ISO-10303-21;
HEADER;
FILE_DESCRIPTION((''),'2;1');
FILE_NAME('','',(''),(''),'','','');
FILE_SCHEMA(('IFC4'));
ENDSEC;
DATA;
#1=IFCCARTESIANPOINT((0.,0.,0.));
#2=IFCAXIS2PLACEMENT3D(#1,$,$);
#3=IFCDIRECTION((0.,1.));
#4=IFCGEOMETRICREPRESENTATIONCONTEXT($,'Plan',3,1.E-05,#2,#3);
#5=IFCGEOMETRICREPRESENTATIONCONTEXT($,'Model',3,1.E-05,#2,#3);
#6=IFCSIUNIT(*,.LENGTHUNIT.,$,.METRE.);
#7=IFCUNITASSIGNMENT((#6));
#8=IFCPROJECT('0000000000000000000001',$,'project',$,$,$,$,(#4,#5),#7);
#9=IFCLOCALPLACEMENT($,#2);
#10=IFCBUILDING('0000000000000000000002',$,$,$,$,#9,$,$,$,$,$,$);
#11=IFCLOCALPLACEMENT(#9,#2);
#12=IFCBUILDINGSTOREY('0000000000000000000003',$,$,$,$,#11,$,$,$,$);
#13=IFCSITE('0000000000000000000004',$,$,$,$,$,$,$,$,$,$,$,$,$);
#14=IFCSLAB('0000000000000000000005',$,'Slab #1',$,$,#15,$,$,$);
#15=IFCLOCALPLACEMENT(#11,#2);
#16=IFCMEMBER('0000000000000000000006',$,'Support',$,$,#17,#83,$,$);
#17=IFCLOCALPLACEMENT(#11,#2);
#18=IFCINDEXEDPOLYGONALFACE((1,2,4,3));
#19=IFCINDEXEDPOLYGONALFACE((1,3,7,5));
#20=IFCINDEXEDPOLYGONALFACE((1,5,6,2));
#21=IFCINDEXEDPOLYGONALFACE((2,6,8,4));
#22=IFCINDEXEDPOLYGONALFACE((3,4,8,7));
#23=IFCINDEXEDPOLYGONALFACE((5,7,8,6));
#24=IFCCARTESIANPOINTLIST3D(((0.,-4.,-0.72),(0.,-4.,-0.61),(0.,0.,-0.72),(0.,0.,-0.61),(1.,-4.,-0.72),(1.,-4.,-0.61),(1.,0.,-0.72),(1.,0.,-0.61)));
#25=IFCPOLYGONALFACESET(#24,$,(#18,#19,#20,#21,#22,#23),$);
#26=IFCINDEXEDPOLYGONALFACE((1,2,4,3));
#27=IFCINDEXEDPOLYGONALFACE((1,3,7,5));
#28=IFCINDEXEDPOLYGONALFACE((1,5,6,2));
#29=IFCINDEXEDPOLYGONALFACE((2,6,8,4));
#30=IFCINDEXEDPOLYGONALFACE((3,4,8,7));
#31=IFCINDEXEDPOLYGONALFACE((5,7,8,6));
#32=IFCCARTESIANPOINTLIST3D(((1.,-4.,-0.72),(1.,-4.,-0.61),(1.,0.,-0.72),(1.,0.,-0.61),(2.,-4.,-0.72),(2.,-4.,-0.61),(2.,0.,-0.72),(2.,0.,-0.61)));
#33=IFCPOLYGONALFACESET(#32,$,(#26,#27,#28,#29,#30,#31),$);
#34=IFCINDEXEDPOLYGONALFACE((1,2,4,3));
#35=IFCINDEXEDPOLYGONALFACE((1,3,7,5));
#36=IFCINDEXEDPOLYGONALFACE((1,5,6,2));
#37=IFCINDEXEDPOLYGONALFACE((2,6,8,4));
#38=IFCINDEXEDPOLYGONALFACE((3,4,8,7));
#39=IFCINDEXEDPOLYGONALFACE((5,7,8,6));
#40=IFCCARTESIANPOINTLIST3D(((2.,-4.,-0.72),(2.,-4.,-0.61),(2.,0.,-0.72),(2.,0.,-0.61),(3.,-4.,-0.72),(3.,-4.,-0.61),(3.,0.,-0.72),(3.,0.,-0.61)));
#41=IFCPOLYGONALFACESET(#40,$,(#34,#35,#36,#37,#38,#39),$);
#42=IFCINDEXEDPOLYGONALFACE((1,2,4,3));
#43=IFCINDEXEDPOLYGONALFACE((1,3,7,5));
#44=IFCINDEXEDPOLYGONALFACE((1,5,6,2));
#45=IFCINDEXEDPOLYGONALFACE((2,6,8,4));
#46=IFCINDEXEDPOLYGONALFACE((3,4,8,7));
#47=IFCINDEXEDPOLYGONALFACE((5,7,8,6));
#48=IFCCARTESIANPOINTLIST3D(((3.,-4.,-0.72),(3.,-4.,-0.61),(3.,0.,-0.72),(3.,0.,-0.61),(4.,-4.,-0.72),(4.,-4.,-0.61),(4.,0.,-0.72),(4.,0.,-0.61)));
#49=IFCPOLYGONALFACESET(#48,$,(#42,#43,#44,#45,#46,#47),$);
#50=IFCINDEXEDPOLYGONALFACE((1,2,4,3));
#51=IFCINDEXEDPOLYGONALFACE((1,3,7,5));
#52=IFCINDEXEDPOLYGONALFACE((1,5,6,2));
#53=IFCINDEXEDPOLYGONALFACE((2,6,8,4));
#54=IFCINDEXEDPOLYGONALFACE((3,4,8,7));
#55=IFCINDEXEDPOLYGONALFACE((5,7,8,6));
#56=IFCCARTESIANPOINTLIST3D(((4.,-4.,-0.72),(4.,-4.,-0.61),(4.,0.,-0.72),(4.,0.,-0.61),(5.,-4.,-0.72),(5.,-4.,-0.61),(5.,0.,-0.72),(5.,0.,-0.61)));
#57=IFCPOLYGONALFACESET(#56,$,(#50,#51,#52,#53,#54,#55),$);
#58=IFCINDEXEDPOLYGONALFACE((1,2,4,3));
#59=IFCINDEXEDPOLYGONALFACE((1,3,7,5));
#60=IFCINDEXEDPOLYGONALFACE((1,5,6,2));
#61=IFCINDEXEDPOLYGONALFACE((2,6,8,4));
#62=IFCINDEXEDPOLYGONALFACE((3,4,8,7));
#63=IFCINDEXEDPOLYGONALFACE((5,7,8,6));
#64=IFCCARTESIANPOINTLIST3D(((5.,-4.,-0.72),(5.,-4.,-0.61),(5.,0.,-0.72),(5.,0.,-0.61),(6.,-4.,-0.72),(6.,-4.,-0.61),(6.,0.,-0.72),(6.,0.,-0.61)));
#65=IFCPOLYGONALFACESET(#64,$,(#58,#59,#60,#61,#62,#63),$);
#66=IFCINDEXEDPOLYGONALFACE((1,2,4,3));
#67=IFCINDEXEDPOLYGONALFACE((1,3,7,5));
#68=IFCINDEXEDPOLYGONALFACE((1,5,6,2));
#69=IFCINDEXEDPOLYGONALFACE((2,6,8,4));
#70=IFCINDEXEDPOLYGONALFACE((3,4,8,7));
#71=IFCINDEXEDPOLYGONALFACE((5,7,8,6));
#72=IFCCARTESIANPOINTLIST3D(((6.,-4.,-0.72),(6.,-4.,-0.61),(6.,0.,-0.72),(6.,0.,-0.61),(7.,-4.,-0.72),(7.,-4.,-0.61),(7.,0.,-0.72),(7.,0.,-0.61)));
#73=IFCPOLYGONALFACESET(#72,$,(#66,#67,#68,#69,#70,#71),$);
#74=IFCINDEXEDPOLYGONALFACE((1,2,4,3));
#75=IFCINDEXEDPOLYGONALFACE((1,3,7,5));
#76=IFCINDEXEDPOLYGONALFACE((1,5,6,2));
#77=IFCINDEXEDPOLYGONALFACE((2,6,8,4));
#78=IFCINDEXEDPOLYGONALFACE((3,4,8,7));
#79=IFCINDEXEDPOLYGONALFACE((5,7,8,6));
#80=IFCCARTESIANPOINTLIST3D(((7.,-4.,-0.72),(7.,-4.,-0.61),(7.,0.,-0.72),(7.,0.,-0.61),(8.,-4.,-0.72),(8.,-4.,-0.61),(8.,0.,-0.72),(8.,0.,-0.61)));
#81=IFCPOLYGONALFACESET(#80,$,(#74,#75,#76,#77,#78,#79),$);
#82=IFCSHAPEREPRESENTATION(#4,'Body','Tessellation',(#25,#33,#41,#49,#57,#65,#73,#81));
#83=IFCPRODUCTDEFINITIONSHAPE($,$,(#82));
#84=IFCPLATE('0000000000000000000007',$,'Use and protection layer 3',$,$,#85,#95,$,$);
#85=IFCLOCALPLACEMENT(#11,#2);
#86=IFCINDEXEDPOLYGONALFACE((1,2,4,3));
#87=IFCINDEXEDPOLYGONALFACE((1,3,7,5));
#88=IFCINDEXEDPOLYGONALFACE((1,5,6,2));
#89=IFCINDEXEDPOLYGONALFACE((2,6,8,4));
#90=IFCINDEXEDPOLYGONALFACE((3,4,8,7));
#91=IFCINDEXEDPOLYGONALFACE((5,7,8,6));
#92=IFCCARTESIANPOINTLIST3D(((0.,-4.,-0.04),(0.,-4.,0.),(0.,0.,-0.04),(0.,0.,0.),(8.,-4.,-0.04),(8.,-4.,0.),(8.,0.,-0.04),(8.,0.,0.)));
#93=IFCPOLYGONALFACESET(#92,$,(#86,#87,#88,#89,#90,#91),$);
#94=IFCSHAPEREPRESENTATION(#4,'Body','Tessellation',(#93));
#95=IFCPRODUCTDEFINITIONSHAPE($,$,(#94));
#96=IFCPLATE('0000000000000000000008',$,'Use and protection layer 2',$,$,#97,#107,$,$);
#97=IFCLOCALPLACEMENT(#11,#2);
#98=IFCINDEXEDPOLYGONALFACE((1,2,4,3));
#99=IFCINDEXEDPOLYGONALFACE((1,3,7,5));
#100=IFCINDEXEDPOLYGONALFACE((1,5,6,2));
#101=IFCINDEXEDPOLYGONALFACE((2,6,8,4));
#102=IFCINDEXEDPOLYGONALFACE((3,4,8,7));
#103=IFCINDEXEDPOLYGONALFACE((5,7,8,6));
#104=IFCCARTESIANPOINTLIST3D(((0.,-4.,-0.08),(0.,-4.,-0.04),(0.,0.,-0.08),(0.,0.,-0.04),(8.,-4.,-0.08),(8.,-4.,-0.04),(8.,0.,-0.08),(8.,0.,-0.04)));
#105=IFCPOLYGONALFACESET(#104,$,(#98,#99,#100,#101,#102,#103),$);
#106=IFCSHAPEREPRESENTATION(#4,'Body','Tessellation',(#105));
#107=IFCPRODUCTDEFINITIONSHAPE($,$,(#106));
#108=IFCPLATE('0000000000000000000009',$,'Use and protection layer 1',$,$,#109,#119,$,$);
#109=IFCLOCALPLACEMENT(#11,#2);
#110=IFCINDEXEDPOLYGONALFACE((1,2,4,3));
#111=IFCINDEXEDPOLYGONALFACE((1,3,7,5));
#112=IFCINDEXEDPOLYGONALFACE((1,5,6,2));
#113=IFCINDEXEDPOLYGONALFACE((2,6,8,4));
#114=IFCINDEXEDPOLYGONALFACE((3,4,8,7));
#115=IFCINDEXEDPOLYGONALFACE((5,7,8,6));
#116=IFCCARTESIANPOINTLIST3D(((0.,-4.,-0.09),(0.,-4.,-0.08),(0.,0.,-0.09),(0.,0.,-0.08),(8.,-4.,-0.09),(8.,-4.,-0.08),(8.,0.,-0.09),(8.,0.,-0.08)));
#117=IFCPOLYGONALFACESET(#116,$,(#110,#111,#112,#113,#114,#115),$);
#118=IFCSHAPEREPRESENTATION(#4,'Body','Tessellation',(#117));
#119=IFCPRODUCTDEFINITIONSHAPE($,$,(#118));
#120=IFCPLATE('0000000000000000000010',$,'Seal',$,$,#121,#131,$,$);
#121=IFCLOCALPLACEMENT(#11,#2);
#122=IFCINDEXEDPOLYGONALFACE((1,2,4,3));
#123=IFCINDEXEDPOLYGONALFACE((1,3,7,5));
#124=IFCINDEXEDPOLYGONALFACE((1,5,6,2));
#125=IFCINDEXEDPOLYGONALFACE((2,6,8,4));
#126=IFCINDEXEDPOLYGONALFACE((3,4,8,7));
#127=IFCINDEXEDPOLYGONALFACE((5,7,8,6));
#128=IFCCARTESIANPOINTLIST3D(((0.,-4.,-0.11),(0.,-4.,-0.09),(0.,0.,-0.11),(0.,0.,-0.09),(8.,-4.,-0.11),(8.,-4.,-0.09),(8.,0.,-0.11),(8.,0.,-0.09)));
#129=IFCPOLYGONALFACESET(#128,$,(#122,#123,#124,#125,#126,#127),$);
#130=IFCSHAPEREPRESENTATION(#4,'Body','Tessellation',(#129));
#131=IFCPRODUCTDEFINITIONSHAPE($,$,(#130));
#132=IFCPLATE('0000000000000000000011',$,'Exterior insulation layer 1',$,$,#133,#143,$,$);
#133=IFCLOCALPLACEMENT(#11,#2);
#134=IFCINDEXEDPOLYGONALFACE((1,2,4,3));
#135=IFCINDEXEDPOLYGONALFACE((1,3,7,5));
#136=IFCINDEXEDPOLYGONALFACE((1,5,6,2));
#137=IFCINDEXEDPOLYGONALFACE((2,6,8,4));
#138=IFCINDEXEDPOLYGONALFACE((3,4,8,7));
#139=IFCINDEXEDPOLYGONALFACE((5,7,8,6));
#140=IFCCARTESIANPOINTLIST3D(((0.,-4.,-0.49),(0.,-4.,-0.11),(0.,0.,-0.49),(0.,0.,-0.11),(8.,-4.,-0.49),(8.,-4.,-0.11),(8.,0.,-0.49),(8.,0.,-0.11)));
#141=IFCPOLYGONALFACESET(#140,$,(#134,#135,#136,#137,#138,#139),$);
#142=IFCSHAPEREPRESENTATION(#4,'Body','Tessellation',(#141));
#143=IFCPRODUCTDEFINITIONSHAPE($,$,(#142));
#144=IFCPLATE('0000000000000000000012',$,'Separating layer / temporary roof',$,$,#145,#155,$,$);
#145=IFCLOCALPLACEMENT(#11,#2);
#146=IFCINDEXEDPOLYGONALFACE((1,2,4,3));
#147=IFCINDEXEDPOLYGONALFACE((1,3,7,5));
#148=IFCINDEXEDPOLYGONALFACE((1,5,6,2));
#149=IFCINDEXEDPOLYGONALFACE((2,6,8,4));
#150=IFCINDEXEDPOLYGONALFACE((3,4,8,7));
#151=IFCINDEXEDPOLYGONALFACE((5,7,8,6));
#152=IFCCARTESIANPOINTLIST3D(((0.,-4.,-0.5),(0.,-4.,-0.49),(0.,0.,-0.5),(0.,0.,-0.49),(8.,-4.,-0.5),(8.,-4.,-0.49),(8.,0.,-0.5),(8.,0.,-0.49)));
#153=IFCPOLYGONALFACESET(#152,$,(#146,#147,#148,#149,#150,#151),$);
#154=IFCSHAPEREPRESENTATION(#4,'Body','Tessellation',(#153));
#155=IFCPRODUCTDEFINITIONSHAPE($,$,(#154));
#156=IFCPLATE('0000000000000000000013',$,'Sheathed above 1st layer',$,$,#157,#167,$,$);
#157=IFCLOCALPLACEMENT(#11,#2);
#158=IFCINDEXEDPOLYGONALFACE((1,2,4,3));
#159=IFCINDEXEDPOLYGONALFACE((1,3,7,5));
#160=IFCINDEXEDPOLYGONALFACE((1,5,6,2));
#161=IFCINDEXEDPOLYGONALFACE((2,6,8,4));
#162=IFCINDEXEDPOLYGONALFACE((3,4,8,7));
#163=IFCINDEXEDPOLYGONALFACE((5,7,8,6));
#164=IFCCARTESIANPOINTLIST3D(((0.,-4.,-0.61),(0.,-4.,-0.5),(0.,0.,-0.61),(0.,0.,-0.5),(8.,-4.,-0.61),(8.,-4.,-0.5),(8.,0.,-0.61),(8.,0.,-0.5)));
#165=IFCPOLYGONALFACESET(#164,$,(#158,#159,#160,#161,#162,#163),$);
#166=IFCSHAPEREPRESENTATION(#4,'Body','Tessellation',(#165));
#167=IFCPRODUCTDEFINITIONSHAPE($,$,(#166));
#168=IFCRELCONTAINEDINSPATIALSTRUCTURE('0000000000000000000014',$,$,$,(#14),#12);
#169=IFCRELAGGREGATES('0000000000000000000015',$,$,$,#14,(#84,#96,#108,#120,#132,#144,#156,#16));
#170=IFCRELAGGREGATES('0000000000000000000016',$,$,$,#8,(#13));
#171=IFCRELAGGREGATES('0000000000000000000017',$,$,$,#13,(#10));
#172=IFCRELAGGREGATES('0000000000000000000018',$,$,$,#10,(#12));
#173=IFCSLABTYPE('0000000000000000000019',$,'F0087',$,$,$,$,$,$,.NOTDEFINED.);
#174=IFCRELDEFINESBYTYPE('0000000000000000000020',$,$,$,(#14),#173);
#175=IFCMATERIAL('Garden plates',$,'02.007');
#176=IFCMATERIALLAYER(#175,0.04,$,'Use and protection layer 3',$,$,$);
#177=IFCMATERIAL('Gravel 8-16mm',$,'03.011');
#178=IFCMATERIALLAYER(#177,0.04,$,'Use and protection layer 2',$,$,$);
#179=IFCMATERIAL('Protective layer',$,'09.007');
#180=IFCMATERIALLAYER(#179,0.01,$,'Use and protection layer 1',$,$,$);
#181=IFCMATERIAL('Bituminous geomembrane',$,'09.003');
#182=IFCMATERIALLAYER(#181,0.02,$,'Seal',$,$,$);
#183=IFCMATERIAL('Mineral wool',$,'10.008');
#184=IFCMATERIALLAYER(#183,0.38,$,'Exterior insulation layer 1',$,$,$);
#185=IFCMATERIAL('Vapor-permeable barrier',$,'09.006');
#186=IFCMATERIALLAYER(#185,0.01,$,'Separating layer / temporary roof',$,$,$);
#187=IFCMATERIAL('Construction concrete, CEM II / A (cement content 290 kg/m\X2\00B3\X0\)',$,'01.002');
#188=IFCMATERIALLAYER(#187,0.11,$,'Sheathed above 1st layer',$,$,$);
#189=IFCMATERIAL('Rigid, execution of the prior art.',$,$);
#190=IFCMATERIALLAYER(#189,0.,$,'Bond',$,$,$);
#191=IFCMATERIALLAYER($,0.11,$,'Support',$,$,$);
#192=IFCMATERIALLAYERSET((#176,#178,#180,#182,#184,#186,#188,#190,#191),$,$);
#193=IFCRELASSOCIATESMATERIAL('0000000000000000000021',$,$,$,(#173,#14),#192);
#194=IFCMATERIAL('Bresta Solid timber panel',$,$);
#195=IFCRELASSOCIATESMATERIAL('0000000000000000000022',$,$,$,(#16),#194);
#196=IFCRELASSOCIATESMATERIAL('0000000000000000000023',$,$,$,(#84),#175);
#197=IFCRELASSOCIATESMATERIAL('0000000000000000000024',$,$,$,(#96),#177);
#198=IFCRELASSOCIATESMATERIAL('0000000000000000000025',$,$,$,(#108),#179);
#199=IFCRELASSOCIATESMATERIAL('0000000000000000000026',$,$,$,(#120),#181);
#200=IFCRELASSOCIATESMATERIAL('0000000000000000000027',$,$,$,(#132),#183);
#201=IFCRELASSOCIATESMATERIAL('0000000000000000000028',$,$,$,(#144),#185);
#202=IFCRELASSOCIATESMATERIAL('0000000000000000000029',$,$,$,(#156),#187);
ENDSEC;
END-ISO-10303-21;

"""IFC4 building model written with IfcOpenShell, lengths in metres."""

from ifc_helpers import new_model, si_unit, direction, frame, frame_2d, origin, origin_with_axes, place, context, project, spatial, rectangle, extrude, material, layer, layer_set, type_object, element, aggregate, save


model = new_model("IFC4")

# Units and contexts
plan_context = context("Plan", 3, precision=1e-05, world=origin(), true_north=direction((0.0, 1.0)))
model_context = context("Model", 3, precision=1e-05, world=origin(), true_north=direction((0.0, 1.0)))
ifc_project = project(units=[si_unit("LENGTHUNIT", "METRE")], contexts=[plan_context, model_context])

# Site, building, storey
site = spatial("IfcSite", under=ifc_project)
building_placement = place(None, origin())
building = spatial("IfcBuilding", under=site, at=building_placement)
storey_placement = place(building_placement, origin())
storey = spatial("IfcBuildingStorey", under=building, at=storey_placement)

# Slab, member, plates
ifc_material_1 = material(Name="Garden plates", Category="02.007")
ifc_layer_1 = layer(ifc_material_1, 0.04, Name="Use and protection layer 3")
ifc_material_2 = material(Name="Gravel 8-16mm", Category="03.011")
ifc_layer_2 = layer(ifc_material_2, 0.04, Name="Use and protection layer 2")
ifc_material_3 = material(Name="Protective layer", Category="09.007")
ifc_layer_3 = layer(ifc_material_3, 0.01, Name="Use and protection layer 1")
ifc_material_4 = material(Name="Bituminous geomembrane", Category="09.003")
ifc_layer_4 = layer(ifc_material_4, 0.02, Name="Seal")
ifc_material_5 = material(Name="Mineral wool", Category="10.008")
ifc_layer_5 = layer(ifc_material_5, 0.38, Name="Exterior insulation layer 1")
ifc_material_6 = material(Name="Vapor-permeable barrier", Category="09.006")
ifc_layer_6 = layer(ifc_material_6, 0.01, Name="Separating layer / temporary roof")
ifc_material_7 = material(Name="Construction concrete, CEM II / A (cement content 290 kg/m³)", Category="01.002")
ifc_layer_7 = layer(ifc_material_7, 0.11, Name="Sheathed above 1st layer")
ifc_material_8 = material(Name="Rigid, execution of the prior art.")
ifc_layer_8 = layer(ifc_material_8, 0.0, Name="Bond")
ifc_layer_9 = layer(None, 0.11, Name="Support")
ifc_layer_set = layer_set([ifc_layer_1, ifc_layer_2, ifc_layer_3, ifc_layer_4, ifc_layer_5, ifc_layer_6, ifc_layer_7, ifc_layer_8, ifc_layer_9])
slab_type = type_object("IfcSlabType", Name="F0087", PredefinedType="NOTDEFINED", material=ifc_layer_set)
slab_placement = place(None, frame((0.0, 0.0, 0.0), z_axis=(0.0, 0.0, -1.0), x_axis=(1.0, 0.0, 0.0)))
slab = element("IfcSlab", 1, at=slab_placement, inside=storey, type_object=slab_type, material=ifc_layer_set, Name="Slab #1")
ifc_material_9 = material(Name="Bresta Solid timber panel")
member_placement = place(slab_placement, origin())
member = element("IfcMember", 2, at=member_placement, material=ifc_material_9, Name="Support", context=plan_context, shape_type="SweptSolid", body=[
    extrude(rectangle(XDim=1.0, YDim=0.11, at=frame_2d((0.5, 0.055), x_axis=(1.0, 0.0))), frame((0.0, 4.0, 0.61), z_axis=(0.0, -1.0, 0.0), x_axis=(1.0, 0.0, 0.0)), (0.0, 0.0, 1.0), 4.0),
    extrude(rectangle(XDim=1.0, YDim=0.11, at=frame_2d((0.5, 0.055), x_axis=(1.0, 0.0))), frame((1.0, 4.0, 0.61), z_axis=(0.0, -1.0, 0.0), x_axis=(1.0, 0.0, 0.0)), (0.0, 0.0, 1.0), 4.0),
    extrude(rectangle(XDim=1.0, YDim=0.11, at=frame_2d((0.5, 0.055), x_axis=(1.0, 0.0))), frame((2.0, 4.0, 0.61), z_axis=(0.0, -1.0, 0.0), x_axis=(1.0, 0.0, 0.0)), (0.0, 0.0, 1.0), 4.0),
    extrude(rectangle(XDim=1.0, YDim=0.11, at=frame_2d((0.5, 0.055), x_axis=(1.0, 0.0))), frame((3.0, 4.0, 0.61), z_axis=(0.0, -1.0, 0.0), x_axis=(1.0, 0.0, 0.0)), (0.0, 0.0, 1.0), 4.0),
    extrude(rectangle(XDim=1.0, YDim=0.11, at=frame_2d((0.5, 0.055), x_axis=(1.0, 0.0))), frame((4.0, 4.0, 0.61), z_axis=(0.0, -1.0, 0.0), x_axis=(1.0, 0.0, 0.0)), (0.0, 0.0, 1.0), 4.0),
    extrude(rectangle(XDim=1.0, YDim=0.11, at=frame_2d((0.5, 0.055), x_axis=(1.0, 0.0))), frame((5.0, 4.0, 0.61), z_axis=(0.0, -1.0, 0.0), x_axis=(1.0, 0.0, 0.0)), (0.0, 0.0, 1.0), 4.0),
    extrude(rectangle(XDim=1.0, YDim=0.11, at=frame_2d((0.5, 0.055), x_axis=(1.0, 0.0))), frame((6.0, 4.0, 0.61), z_axis=(0.0, -1.0, 0.0), x_axis=(1.0, 0.0, 0.0)), (0.0, 0.0, 1.0), 4.0),
    extrude(rectangle(XDim=1.0, YDim=0.11, at=frame_2d((0.5, 0.055), x_axis=(1.0, 0.0))), frame((7.0, 4.0, 0.61), z_axis=(0.0, -1.0, 0.0), x_axis=(1.0, 0.0, 0.0)), (0.0, 0.0, 1.0), 4.0),
])
plate_1_placement = place(slab_placement, origin())
plate_1 = element("IfcPlate", 3, at=plate_1_placement, material=ifc_material_1, Name="Use and protection layer 3", context=plan_context, shape_type="SweptSolid", body=[
    extrude(rectangle(XDim=8.0, YDim=4.0, at=frame_2d((4.0, 2.0), x_axis=(1.0, 0.0))), origin_with_axes(), (0.0, 0.0, 1.0), 0.04),
])
plate_2_placement = place(slab_placement, origin())
plate_2 = element("IfcPlate", 4, at=plate_2_placement, material=ifc_material_2, Name="Use and protection layer 2", context=plan_context, shape_type="SweptSolid", body=[
    extrude(rectangle(XDim=8.0, YDim=4.0, at=frame_2d((4.0, 2.0), x_axis=(1.0, 0.0))), frame((0.0, 0.0, 0.04), z_axis=(0.0, 0.0, 1.0), x_axis=(1.0, 0.0, 0.0)), (0.0, 0.0, 1.0), 0.04),
])
plate_3_placement = place(slab_placement, origin())
plate_3 = element("IfcPlate", 5, at=plate_3_placement, material=ifc_material_3, Name="Use and protection layer 1", context=plan_context, shape_type="SweptSolid", body=[
    extrude(rectangle(XDim=8.0, YDim=4.0, at=frame_2d((4.0, 2.0), x_axis=(1.0, 0.0))), frame((0.0, 0.0, 0.08), z_axis=(0.0, 0.0, 1.0), x_axis=(1.0, 0.0, 0.0)), (0.0, 0.0, 1.0), 0.01),
])
plate_4_placement = place(slab_placement, origin())
plate_4 = element("IfcPlate", 6, at=plate_4_placement, material=ifc_material_4, Name="Seal", context=plan_context, shape_type="SweptSolid", body=[
    extrude(rectangle(XDim=8.0, YDim=4.0, at=frame_2d((4.0, 2.0), x_axis=(1.0, 0.0))), frame((0.0, 0.0, 0.09), z_axis=(0.0, 0.0, 1.0), x_axis=(1.0, 0.0, 0.0)), (0.0, 0.0, 1.0), 0.02),
])
plate_5_placement = place(slab_placement, origin())
plate_5 = element("IfcPlate", 7, at=plate_5_placement, material=ifc_material_5, Name="Exterior insulation layer 1", context=plan_context, shape_type="SweptSolid", body=[
    extrude(rectangle(XDim=8.0, YDim=4.0, at=frame_2d((4.0, 2.0), x_axis=(1.0, 0.0))), frame((0.0, 0.0, 0.11), z_axis=(0.0, 0.0, 1.0), x_axis=(1.0, 0.0, 0.0)), (0.0, 0.0, 1.0), 0.38),
])
plate_6_placement = place(slab_placement, origin())
plate_6 = element("IfcPlate", 8, at=plate_6_placement, material=ifc_material_6, Name="Separating layer / temporary roof", context=plan_context, shape_type="SweptSolid", body=[
    extrude(rectangle(XDim=8.0, YDim=4.0, at=frame_2d((4.0, 2.0), x_axis=(1.0, 0.0))), frame((0.0, 0.0, 0.49), z_axis=(0.0, 0.0, 1.0), x_axis=(1.0, 0.0, 0.0)), (0.0, 0.0, 1.0), 0.01),
])
plate_7_placement = place(slab_placement, origin())
plate_7 = element("IfcPlate", 9, at=plate_7_placement, material=ifc_material_7, Name="Sheathed above 1st layer", context=plan_context, shape_type="SweptSolid", body=[
    extrude(rectangle(XDim=8.0, YDim=4.0, at=frame_2d((4.0, 2.0), x_axis=(1.0, 0.0))), frame((0.0, 0.0, 0.5), z_axis=(0.0, 0.0, 1.0), x_axis=(1.0, 0.0, 0.0)), (0.0, 0.0, 1.0), 0.11),
])
aggregate(slab, [plate_1, plate_2, plate_3, plate_4, plate_5, plate_6, plate_7, member])

save(model, "model.ifc")
